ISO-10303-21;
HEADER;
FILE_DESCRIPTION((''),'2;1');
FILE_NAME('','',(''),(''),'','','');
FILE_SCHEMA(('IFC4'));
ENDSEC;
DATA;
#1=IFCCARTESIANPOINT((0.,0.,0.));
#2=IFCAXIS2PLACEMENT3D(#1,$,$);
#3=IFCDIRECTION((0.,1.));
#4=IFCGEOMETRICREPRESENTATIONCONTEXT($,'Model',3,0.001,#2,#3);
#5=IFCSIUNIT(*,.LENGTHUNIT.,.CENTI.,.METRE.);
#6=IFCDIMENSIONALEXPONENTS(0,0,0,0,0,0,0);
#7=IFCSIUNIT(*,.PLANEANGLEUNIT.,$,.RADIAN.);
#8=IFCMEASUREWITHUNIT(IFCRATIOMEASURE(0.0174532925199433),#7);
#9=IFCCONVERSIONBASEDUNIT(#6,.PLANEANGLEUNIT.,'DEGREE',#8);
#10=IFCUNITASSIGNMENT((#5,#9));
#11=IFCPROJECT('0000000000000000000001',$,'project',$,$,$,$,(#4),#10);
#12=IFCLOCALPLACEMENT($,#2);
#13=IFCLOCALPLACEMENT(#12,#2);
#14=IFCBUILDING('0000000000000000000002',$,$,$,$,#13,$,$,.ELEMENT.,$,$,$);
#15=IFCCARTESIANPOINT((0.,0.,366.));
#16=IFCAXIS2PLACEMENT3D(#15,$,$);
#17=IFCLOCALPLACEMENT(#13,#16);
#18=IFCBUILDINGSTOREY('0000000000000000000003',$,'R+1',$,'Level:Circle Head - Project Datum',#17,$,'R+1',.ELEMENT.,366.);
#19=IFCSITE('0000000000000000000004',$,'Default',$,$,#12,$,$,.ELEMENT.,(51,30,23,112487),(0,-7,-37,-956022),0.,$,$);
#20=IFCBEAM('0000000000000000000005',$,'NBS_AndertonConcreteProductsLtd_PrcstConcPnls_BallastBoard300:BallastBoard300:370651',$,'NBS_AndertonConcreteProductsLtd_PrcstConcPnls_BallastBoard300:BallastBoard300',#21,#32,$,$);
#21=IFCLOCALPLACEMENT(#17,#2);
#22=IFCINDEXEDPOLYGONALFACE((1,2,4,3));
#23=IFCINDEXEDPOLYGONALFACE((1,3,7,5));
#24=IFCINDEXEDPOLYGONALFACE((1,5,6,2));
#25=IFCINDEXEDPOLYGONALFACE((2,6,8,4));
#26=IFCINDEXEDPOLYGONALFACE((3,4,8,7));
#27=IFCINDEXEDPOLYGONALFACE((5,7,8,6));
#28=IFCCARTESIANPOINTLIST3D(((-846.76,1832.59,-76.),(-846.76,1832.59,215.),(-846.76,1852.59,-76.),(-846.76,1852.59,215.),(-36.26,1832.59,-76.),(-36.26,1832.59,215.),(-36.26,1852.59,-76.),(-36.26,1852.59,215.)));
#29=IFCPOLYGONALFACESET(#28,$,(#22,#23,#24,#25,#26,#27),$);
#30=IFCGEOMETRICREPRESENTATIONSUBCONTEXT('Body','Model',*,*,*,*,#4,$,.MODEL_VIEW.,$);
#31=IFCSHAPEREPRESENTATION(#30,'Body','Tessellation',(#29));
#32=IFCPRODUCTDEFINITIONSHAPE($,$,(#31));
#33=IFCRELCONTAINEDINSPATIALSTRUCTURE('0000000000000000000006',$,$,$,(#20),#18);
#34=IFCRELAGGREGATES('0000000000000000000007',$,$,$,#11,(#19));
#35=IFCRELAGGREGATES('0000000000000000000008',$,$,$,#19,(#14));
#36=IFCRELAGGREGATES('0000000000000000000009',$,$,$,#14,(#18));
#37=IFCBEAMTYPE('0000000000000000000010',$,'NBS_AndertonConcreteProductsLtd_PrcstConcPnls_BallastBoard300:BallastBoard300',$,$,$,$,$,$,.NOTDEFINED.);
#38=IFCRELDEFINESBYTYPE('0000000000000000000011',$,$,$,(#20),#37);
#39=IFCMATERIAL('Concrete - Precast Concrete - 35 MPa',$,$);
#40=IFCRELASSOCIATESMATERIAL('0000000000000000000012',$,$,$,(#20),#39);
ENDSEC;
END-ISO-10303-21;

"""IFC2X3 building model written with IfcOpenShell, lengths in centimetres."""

from ifc_helpers import new_model, entity, si_unit, converted_unit, direction, frame, frame_2d, origin, place, context, subcontext, project, spatial, rectangle, extrude, material, type_object, element, save


model = new_model("IFC2X3")

# Units and contexts
model_context = context("Model", 3, precision=0.001, world=origin(), true_north=direction((0.0, 1.0)))
body_context = subcontext(model_context, "Body", "Model", "MODEL_VIEW")
ifc_project = project(units=[si_unit("LENGTHUNIT", "METRE", prefix="CENTI"), converted_unit("PLANEANGLEUNIT", "DEGREE", entity("IfcRatioMeasure", 0.0174532925199433), si_unit("PLANEANGLEUNIT", "RADIAN"), dimensions=[0, 0, 0, 0, 0, 0, 0])], contexts=[model_context])

# Site, building, storey
site_placement = place(None, origin())
site = spatial("IfcSite", under=ifc_project, at=site_placement, Name="Default", CompositionType="ELEMENT", RefLatitude=(51, 30, 23, 112487), RefLongitude=(0, -7, -37, -956022), RefElevation=0.0)
building_placement = place(site_placement, origin())
building = spatial("IfcBuilding", under=site, at=building_placement, CompositionType="ELEMENT")
storey_placement = place(building_placement, frame((0.0, 0.0, 366.0)))
storey = spatial("IfcBuildingStorey", under=building, at=storey_placement, Name="R+1", ObjectType="Level:Circle Head - Project Datum", LongName="R+1", CompositionType="ELEMENT", Elevation=366.0)

# Beam
ifc_material = material(Name="Concrete - Precast Concrete - 35 MPa")
beam_type = type_object("IfcBeamType", Name="NBS_AndertonConcreteProductsLtd_PrcstConcPnls_BallastBoard300:BallastBoard300", PredefinedType="NOTDEFINED")
beam_placement = place(storey_placement, origin())
element("IfcBeam", 1, at=beam_placement, inside=storey, type_object=beam_type, material=ifc_material, Name="NBS_AndertonConcreteProductsLtd_PrcstConcPnls_BallastBoard300:BallastBoard300:370651", ObjectType="NBS_AndertonConcreteProductsLtd_PrcstConcPnls_BallastBoard300:BallastBoard300", context=body_context, shape_type="SweptSolid", body=[
    extrude(rectangle(XDim=291.0, YDim=20.0, at=frame_2d((0.0, 0.0), x_axis=(0.0, 1.0))), frame((-846.76, 1842.59, 69.5), z_axis=(1.0, 0.0, 0.0), x_axis=(0.0, 1.0, 0.0)), (0.0, 0.0, 1.0), 810.5),
])

save(model, "model.ifc")
